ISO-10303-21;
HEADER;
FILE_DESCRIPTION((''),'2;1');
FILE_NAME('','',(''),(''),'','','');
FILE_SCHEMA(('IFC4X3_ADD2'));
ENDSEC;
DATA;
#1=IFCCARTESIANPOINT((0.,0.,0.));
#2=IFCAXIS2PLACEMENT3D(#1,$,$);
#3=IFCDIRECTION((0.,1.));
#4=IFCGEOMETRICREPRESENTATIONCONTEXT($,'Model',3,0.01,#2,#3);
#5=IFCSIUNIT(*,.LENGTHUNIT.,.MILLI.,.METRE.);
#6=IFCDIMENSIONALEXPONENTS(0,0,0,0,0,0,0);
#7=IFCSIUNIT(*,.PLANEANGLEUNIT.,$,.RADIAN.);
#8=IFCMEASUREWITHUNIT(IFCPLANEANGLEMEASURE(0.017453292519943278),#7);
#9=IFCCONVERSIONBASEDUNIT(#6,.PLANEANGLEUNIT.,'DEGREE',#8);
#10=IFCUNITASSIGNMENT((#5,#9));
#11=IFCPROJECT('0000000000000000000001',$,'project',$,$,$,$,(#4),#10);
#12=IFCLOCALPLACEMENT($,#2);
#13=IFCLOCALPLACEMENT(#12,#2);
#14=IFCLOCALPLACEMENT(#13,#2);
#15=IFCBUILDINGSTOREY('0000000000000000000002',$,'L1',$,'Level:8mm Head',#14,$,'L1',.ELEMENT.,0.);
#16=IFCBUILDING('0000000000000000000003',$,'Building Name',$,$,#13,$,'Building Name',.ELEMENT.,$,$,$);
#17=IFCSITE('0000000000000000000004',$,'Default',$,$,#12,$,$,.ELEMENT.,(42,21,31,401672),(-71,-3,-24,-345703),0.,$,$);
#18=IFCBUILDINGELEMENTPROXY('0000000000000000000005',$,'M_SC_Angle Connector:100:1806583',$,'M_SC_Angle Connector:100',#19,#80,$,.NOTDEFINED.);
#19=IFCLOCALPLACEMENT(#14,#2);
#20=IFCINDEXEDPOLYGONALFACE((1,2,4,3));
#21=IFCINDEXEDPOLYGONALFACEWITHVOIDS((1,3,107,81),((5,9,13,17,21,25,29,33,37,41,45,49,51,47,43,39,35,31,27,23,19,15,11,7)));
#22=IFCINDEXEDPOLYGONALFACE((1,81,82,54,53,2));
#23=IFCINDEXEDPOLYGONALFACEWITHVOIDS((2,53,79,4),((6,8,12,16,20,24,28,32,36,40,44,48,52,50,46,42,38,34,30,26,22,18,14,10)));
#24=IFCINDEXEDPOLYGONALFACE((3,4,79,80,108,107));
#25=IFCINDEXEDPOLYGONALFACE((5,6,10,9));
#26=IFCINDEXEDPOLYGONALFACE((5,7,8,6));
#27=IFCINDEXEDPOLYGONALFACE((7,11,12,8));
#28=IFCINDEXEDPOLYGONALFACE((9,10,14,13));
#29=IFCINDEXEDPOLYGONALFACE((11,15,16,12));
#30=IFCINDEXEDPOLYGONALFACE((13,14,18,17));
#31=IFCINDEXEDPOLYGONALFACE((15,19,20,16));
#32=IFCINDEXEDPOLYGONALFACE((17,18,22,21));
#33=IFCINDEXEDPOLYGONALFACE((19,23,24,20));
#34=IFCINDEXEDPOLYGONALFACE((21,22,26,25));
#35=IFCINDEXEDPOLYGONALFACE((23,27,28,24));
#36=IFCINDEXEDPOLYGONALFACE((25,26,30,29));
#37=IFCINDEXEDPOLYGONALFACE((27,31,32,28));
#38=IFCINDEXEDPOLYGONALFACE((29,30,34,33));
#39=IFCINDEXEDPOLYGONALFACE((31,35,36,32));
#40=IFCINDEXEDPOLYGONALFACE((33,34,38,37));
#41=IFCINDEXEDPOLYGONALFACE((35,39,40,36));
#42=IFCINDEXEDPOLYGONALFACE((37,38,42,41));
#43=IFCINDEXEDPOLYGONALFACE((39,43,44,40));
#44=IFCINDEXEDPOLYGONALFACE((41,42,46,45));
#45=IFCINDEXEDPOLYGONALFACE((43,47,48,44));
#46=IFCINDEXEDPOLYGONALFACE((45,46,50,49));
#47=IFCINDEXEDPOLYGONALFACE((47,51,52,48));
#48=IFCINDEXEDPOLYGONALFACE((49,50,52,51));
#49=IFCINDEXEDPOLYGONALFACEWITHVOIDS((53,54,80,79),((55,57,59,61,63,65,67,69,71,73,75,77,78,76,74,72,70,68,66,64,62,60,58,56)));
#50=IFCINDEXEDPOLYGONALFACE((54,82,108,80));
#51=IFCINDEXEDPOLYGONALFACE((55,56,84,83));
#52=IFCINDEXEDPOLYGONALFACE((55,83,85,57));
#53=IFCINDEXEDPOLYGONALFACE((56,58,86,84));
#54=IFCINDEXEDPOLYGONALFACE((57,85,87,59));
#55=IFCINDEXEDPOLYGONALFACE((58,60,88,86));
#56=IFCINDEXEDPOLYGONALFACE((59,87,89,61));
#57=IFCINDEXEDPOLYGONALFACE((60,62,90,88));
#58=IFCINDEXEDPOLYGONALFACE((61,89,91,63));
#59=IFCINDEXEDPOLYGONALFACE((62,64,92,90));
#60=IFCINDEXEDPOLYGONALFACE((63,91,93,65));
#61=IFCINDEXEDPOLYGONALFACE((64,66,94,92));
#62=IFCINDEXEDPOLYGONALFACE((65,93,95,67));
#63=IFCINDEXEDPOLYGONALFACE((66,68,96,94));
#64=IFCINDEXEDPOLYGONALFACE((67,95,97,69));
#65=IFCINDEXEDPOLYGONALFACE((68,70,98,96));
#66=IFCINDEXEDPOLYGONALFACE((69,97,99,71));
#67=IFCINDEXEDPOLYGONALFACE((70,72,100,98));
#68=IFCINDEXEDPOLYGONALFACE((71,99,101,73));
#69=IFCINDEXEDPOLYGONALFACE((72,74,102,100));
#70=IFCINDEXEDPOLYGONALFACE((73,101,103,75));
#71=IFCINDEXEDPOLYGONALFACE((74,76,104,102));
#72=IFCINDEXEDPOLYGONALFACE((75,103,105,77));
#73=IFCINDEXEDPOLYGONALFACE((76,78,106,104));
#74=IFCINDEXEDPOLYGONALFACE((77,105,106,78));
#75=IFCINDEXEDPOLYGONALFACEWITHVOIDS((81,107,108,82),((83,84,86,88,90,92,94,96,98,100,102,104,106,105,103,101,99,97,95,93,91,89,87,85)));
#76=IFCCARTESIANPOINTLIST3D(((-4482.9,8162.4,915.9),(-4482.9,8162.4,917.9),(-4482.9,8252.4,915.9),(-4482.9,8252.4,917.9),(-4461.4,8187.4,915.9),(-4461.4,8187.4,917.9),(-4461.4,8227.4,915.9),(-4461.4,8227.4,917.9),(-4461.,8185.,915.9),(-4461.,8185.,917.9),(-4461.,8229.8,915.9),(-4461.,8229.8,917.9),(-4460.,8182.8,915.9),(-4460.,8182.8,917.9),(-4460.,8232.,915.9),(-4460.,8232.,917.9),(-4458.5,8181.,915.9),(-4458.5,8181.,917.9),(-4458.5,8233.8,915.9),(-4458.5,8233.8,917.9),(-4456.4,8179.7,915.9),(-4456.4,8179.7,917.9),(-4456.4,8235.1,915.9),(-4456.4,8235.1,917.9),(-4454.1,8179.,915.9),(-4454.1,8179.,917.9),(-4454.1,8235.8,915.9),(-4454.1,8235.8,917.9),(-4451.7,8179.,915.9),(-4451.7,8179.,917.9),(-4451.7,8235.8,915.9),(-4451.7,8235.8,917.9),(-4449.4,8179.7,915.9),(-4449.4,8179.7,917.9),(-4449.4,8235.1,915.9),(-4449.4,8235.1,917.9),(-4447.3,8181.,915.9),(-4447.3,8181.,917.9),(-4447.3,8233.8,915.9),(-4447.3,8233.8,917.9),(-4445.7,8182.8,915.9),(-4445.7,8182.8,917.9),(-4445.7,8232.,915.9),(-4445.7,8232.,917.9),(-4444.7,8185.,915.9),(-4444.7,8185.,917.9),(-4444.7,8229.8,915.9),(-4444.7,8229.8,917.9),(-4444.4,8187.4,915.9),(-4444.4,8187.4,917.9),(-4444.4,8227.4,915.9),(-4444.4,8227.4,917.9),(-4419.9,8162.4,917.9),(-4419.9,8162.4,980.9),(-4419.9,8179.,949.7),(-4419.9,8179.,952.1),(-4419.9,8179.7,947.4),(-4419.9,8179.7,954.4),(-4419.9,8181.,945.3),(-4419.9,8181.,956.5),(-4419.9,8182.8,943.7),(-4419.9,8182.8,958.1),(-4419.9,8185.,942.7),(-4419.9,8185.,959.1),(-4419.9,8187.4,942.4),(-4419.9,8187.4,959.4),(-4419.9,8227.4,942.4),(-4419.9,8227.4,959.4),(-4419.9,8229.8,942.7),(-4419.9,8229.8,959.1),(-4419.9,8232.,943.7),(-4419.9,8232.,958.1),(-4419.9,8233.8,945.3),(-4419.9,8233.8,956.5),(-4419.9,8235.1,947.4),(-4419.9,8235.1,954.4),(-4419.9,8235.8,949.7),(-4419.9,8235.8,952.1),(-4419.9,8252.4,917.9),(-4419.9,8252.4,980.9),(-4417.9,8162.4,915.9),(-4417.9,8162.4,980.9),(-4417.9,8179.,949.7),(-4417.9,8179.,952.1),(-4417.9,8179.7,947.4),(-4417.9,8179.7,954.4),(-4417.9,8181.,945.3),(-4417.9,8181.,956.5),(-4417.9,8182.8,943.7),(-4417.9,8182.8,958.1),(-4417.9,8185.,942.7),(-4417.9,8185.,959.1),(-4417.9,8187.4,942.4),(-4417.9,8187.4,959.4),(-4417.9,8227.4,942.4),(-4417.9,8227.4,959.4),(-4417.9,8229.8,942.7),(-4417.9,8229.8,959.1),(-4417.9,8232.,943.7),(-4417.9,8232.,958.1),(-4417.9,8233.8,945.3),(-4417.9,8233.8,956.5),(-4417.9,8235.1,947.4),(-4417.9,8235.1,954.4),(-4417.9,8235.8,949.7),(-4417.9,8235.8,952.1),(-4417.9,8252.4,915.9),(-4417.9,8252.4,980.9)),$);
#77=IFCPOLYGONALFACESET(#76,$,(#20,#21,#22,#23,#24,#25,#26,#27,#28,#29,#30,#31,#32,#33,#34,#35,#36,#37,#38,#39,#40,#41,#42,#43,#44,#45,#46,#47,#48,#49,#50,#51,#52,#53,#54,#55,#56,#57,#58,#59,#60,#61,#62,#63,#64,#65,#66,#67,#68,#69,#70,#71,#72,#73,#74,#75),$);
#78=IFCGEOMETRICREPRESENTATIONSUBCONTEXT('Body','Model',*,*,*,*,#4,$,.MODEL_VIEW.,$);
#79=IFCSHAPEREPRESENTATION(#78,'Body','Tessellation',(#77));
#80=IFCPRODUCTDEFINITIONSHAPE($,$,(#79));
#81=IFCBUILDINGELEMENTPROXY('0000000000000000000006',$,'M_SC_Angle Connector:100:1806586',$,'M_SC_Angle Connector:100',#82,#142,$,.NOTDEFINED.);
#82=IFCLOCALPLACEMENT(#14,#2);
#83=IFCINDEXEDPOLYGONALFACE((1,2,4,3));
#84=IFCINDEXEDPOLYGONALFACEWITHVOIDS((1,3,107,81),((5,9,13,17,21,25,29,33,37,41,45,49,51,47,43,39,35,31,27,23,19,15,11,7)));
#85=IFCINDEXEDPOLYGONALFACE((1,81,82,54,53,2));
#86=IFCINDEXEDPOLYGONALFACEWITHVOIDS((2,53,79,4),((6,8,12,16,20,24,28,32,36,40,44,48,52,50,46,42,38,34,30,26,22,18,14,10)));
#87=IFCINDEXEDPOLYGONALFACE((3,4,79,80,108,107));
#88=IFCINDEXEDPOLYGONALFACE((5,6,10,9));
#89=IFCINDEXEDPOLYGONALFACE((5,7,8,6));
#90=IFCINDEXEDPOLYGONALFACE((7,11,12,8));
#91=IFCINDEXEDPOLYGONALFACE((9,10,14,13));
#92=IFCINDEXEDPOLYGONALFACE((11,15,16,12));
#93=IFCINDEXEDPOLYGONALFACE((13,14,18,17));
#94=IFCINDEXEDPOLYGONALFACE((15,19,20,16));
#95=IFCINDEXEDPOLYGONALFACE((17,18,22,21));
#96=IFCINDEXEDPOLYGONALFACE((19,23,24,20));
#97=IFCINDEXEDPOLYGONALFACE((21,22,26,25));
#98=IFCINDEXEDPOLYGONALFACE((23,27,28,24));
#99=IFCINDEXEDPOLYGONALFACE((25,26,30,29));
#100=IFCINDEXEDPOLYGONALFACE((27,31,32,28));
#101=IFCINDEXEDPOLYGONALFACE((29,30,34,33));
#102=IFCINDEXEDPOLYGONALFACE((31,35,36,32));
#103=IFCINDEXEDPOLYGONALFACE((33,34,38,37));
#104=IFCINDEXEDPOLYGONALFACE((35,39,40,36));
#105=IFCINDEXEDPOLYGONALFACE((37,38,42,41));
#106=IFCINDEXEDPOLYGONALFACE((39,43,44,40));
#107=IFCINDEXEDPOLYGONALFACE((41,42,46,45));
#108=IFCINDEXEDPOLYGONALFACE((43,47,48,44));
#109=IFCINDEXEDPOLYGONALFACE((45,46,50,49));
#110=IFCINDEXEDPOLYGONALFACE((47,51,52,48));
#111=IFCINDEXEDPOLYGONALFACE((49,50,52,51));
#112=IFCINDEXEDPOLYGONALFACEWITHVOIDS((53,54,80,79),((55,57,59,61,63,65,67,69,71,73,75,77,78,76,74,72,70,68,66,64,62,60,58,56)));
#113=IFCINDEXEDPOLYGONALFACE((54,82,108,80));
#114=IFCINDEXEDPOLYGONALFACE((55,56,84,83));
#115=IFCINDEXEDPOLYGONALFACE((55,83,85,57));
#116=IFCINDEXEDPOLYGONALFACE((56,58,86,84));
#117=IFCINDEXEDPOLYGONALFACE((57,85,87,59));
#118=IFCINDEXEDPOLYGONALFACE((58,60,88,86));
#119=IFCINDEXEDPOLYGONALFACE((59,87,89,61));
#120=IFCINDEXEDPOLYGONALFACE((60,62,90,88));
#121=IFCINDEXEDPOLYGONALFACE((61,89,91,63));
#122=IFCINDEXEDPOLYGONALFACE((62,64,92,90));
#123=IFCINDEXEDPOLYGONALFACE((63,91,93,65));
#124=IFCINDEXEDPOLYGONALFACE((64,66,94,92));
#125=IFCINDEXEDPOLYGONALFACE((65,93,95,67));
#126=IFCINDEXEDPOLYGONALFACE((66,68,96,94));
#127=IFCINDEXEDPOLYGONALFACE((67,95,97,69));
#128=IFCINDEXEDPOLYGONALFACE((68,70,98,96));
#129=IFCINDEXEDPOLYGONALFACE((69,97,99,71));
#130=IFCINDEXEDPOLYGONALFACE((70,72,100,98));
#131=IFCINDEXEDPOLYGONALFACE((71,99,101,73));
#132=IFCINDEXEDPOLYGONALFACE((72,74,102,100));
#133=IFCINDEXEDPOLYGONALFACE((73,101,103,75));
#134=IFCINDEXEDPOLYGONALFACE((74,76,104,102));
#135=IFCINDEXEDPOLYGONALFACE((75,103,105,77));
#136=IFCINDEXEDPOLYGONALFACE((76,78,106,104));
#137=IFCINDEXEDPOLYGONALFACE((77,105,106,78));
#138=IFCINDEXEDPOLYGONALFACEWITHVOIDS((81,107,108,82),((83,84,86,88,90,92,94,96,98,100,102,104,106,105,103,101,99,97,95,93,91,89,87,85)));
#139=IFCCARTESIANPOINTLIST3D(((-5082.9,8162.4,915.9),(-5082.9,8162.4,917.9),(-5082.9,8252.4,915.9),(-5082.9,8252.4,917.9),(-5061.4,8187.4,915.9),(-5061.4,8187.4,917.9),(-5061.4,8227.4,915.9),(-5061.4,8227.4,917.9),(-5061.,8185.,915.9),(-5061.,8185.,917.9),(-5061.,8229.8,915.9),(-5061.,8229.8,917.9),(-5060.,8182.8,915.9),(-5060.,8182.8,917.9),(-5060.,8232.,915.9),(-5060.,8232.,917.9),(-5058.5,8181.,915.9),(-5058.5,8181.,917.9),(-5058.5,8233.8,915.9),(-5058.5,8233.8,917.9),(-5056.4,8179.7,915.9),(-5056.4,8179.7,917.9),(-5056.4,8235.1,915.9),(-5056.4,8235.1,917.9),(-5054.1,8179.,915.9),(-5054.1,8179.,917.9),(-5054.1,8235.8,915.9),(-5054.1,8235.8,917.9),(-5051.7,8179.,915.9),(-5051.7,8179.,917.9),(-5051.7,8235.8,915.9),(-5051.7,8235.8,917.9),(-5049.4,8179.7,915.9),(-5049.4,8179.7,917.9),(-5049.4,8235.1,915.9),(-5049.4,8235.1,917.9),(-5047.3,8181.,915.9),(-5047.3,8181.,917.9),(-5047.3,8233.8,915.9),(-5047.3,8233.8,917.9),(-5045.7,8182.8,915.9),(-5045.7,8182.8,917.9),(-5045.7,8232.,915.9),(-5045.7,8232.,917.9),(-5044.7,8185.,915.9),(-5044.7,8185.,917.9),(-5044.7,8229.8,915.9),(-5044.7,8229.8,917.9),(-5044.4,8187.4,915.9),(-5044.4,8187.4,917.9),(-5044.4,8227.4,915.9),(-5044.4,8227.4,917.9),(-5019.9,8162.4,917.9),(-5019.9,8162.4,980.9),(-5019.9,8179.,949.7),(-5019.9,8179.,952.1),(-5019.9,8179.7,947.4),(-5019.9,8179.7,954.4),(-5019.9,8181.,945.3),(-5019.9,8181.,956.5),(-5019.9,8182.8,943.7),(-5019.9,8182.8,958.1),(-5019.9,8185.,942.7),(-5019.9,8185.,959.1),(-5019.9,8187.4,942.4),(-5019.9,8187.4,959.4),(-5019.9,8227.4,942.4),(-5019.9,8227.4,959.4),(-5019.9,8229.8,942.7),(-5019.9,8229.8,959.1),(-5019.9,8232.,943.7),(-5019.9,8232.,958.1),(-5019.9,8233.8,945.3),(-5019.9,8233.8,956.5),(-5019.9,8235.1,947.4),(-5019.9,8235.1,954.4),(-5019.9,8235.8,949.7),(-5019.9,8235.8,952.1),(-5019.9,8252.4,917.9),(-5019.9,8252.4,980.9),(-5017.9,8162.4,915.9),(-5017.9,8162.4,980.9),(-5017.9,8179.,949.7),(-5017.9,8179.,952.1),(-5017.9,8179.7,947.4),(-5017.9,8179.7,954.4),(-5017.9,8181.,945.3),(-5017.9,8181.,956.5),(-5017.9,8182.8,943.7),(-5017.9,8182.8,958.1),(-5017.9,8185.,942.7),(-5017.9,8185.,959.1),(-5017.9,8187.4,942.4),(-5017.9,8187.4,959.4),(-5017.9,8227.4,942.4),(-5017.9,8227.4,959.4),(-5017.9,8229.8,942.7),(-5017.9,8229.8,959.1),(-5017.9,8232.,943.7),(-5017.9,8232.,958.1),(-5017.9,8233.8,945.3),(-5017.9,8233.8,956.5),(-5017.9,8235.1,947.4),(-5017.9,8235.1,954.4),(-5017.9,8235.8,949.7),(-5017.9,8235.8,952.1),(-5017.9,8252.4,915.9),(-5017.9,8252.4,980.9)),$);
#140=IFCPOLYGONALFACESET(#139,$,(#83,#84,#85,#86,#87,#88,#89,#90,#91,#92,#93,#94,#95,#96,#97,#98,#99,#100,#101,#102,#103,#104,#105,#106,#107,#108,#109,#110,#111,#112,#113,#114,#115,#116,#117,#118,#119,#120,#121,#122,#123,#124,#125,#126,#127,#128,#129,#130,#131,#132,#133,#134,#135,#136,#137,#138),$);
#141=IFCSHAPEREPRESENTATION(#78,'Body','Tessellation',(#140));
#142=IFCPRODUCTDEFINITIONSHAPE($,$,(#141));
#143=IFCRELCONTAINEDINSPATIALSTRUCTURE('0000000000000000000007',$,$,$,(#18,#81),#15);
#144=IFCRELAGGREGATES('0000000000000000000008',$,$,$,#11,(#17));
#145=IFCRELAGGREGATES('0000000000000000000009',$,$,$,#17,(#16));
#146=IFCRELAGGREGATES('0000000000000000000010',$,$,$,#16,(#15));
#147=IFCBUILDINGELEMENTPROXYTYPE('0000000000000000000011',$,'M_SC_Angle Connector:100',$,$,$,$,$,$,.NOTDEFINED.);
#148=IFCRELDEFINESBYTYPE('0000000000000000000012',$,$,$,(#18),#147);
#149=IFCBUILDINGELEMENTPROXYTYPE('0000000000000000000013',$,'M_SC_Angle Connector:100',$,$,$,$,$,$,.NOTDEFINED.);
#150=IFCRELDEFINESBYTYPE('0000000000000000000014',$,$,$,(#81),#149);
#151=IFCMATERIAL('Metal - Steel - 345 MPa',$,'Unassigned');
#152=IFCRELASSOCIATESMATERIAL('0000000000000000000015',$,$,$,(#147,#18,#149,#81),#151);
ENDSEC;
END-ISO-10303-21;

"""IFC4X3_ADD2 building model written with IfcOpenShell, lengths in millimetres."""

from ifc_helpers import new_model, entity, si_unit, converted_unit, direction, frame, frame_2d, origin, place, context, subcontext, project, spatial, polyline, circle_curve, parameter, trimmed, segment, composite_curve, outline, extrude, source, transform, mapped, material, type_object, type_shapes, element, save


model = new_model("IFC4X3_ADD2")

# Units and contexts
model_context = context("Model", 3, precision=0.01, world=origin(), true_north=direction((0.0, 1.0)))
body_context = subcontext(model_context, "Body", "Model", "MODEL_VIEW")
ifc_project = project(units=[si_unit("LENGTHUNIT", "METRE", prefix="MILLI"), converted_unit("PLANEANGLEUNIT", "DEGREE", entity("IfcPlaneAngleMeasure", 0.017453292519943278), si_unit("PLANEANGLEUNIT", "RADIAN"), dimensions=[0, 0, 0, 0, 0, 0, 0])], contexts=[model_context])

# Site, building, storey
site_placement = place(None, origin())
site = spatial("IfcSite", under=ifc_project, at=site_placement, Name="Default", CompositionType="ELEMENT", RefLatitude=(42, 21, 31, 401672), RefLongitude=(-71, -3, -24, -345703), RefElevation=0.0)
building_placement = place(site_placement, origin())
building = spatial("IfcBuilding", under=site, at=building_placement, Name="Building Name", LongName="Building Name", CompositionType="ELEMENT")
storey_placement = place(building_placement, origin())
storey = spatial("IfcBuildingStorey", under=building, at=storey_placement, Name="L1", ObjectType="Level:8mm Head", LongName="L1", CompositionType="ELEMENT", Elevation=0.0)

# Building element proxies, openings
ifc_material_1 = material(Name="Metal - Steel - 345 MPa", Category="Unassigned")
building_element_proxy_type_1 = type_object("IfcBuildingElementProxyType", Name="M_SC_Angle Connector:100", PredefinedType="NOTDEFINED", material=ifc_material_1)
shared_shape_1 = source(origin(), body_context, "Body", "SweptSolid", [
    extrude(outline(polyline([(-42.7, -22.3), (22.3, -22.3), (22.3, 42.7), (20.3, 42.7), (20.3, -20.3), (-42.7, -20.3), (-42.7, -22.3)])), frame((22.3, -45.0, 22.3), z_axis=(0.0, 1.0, 0.0), x_axis=(-1.0, 0.0, 0.0)), (0.0, 0.0, 1.0), 90.0),
])
type_shapes(building_element_proxy_type_1, [shared_shape_1])
proxy_1_placement = place(storey_placement, frame((-4417.9, 8207.4, 915.9), z_axis=(0.0, 0.0, 1.0), x_axis=(-1.0, 0.0, 0.0)))
proxy_1 = element("IfcBuildingElementProxy", 1, at=proxy_1_placement, inside=storey, type_object=building_element_proxy_type_1, material=ifc_material_1, Name="M_SC_Angle Connector:100:1806583", ObjectType="M_SC_Angle Connector:100", PredefinedType="NOTDEFINED", context=body_context, shape_type="MappedRepresentation", body=[
    mapped(shared_shape_1, transform((0.0, 0.0, 0.0), scale=1.0)),
])
opening_1_placement = place(storey_placement, frame((-4417.9, 8207.4, 915.9)))
element("IfcOpeningElement", 2, at=opening_1_placement, cuts=proxy_1, PredefinedType="OPENING", context=body_context, shape_type="SweptSolid", body=[
    extrude(outline(composite_curve([segment(polyline([(-20.0, -8.5), (20.0, -8.5)]), True, "CONTINUOUS"), segment(trimmed(circle_curve(frame_2d((20.0, 0.0), x_axis=(0.0, 1.0)), 8.5), [parameter(180.0)], [parameter(360.0)], True, "PARAMETER"), True, "CONTINUOUS"), segment(polyline([(20.0, 8.5), (-20.0, 8.5)]), True, "CONTINUOUS"), segment(trimmed(circle_curve(frame_2d((-20.0, 0.0), x_axis=(0.0, 1.0)), 8.5), [parameter(360.0)], [parameter(180.0)], True, "PARAMETER"), True, "CONTINUOUS")], self_intersect=False)), frame((-2.0, 0.0, 35.0), z_axis=(1.0, 0.0, 0.0), x_axis=(0.0, 1.0, 0.0)), (0.0, 0.0, 1.0), 2.0),
])
opening_2_placement = place(storey_placement, frame((-4417.9, 8207.4, 915.9)))
element("IfcOpeningElement", 3, at=opening_2_placement, cuts=proxy_1, PredefinedType="OPENING", context=body_context, shape_type="SweptSolid", body=[
    extrude(outline(composite_curve([segment(polyline([(-20.0, -8.5), (20.0, -8.5)]), True, "CONTINUOUS"), segment(trimmed(circle_curve(frame_2d((20.0, 0.0), x_axis=(0.0, -1.0)), 8.5), [parameter(360.0)], [parameter(180.0)], True, "PARAMETER"), True, "CONTINUOUS"), segment(polyline([(20.0, 8.5), (-20.0, 8.5)]), True, "CONTINUOUS"), segment(trimmed(circle_curve(frame_2d((-20.0, 0.0), x_axis=(0.0, -1.0)), 8.5), [parameter(180.0)], [parameter(360.0)], True, "PARAMETER"), True, "CONTINUOUS")], self_intersect=False)), frame((-35.0, 0.0, 2.0), z_axis=(0.0, 0.0, -1.0), x_axis=(0.0, 1.0, 0.0)), (0.0, 0.0, 1.0), 2.0),
])
building_element_proxy_type_2 = type_object("IfcBuildingElementProxyType", Name="M_SC_Angle Connector:100", PredefinedType="NOTDEFINED", material=ifc_material_1)
shared_shape_2 = source(origin(), body_context, "Body", "SweptSolid", [
    extrude(outline(polyline([(-42.7, -22.3), (22.3, -22.3), (22.3, 42.7), (20.3, 42.7), (20.3, -20.3), (-42.7, -20.3), (-42.7, -22.3)])), frame((22.3, -45.0, 22.3), z_axis=(0.0, 1.0, 0.0), x_axis=(-1.0, 0.0, 0.0)), (0.0, 0.0, 1.0), 90.0),
])
type_shapes(building_element_proxy_type_2, [shared_shape_2])
proxy_2_placement = place(storey_placement, frame((-5017.9, 8207.4, 915.9), z_axis=(0.0, 0.0, 1.0), x_axis=(-1.0, 0.0, 0.0)))
proxy_2 = element("IfcBuildingElementProxy", 4, at=proxy_2_placement, inside=storey, type_object=building_element_proxy_type_2, material=ifc_material_1, Name="M_SC_Angle Connector:100:1806586", ObjectType="M_SC_Angle Connector:100", PredefinedType="NOTDEFINED", context=body_context, shape_type="MappedRepresentation", body=[
    mapped(shared_shape_2, transform((0.0, 0.0, 0.0), scale=1.0)),
])
opening_3_placement = place(storey_placement, frame((-5017.9, 8207.4, 915.9)))
element("IfcOpeningElement", 5, at=opening_3_placement, cuts=proxy_2, PredefinedType="OPENING", context=body_context, shape_type="SweptSolid", body=[
    extrude(outline(composite_curve([segment(polyline([(-20.0, -8.5), (20.0, -8.5)]), True, "CONTINUOUS"), segment(trimmed(circle_curve(frame_2d((20.0, 0.0), x_axis=(0.0, 1.0)), 8.5), [parameter(180.0)], [parameter(360.0)], True, "PARAMETER"), True, "CONTINUOUS"), segment(polyline([(20.0, 8.5), (-20.0, 8.5)]), True, "CONTINUOUS"), segment(trimmed(circle_curve(frame_2d((-20.0, 0.0), x_axis=(0.0, 1.0)), 8.5), [parameter(360.0)], [parameter(180.0)], True, "PARAMETER"), True, "CONTINUOUS")], self_intersect=False)), frame((-2.0, 0.0, 35.0), z_axis=(1.0, 0.0, 0.0), x_axis=(0.0, 1.0, 0.0)), (0.0, 0.0, 1.0), 2.0),
])
opening_4_placement = place(storey_placement, frame((-5017.9, 8207.4, 915.9)))
element("IfcOpeningElement", 6, at=opening_4_placement, cuts=proxy_2, PredefinedType="OPENING", context=body_context, shape_type="SweptSolid", body=[
    extrude(outline(composite_curve([segment(polyline([(-20.0, -8.5), (20.0, -8.5)]), True, "CONTINUOUS"), segment(trimmed(circle_curve(frame_2d((20.0, 0.0), x_axis=(0.0, -1.0)), 8.5), [parameter(360.0)], [parameter(180.0)], True, "PARAMETER"), True, "CONTINUOUS"), segment(polyline([(20.0, 8.5), (-20.0, 8.5)]), True, "CONTINUOUS"), segment(trimmed(circle_curve(frame_2d((-20.0, 0.0), x_axis=(0.0, -1.0)), 8.5), [parameter(180.0)], [parameter(360.0)], True, "PARAMETER"), True, "CONTINUOUS")], self_intersect=False)), frame((-35.0, 0.0, 2.0), z_axis=(0.0, 0.0, -1.0), x_axis=(0.0, 1.0, 0.0)), (0.0, 0.0, 1.0), 2.0),
])

save(model, "model.ifc")
